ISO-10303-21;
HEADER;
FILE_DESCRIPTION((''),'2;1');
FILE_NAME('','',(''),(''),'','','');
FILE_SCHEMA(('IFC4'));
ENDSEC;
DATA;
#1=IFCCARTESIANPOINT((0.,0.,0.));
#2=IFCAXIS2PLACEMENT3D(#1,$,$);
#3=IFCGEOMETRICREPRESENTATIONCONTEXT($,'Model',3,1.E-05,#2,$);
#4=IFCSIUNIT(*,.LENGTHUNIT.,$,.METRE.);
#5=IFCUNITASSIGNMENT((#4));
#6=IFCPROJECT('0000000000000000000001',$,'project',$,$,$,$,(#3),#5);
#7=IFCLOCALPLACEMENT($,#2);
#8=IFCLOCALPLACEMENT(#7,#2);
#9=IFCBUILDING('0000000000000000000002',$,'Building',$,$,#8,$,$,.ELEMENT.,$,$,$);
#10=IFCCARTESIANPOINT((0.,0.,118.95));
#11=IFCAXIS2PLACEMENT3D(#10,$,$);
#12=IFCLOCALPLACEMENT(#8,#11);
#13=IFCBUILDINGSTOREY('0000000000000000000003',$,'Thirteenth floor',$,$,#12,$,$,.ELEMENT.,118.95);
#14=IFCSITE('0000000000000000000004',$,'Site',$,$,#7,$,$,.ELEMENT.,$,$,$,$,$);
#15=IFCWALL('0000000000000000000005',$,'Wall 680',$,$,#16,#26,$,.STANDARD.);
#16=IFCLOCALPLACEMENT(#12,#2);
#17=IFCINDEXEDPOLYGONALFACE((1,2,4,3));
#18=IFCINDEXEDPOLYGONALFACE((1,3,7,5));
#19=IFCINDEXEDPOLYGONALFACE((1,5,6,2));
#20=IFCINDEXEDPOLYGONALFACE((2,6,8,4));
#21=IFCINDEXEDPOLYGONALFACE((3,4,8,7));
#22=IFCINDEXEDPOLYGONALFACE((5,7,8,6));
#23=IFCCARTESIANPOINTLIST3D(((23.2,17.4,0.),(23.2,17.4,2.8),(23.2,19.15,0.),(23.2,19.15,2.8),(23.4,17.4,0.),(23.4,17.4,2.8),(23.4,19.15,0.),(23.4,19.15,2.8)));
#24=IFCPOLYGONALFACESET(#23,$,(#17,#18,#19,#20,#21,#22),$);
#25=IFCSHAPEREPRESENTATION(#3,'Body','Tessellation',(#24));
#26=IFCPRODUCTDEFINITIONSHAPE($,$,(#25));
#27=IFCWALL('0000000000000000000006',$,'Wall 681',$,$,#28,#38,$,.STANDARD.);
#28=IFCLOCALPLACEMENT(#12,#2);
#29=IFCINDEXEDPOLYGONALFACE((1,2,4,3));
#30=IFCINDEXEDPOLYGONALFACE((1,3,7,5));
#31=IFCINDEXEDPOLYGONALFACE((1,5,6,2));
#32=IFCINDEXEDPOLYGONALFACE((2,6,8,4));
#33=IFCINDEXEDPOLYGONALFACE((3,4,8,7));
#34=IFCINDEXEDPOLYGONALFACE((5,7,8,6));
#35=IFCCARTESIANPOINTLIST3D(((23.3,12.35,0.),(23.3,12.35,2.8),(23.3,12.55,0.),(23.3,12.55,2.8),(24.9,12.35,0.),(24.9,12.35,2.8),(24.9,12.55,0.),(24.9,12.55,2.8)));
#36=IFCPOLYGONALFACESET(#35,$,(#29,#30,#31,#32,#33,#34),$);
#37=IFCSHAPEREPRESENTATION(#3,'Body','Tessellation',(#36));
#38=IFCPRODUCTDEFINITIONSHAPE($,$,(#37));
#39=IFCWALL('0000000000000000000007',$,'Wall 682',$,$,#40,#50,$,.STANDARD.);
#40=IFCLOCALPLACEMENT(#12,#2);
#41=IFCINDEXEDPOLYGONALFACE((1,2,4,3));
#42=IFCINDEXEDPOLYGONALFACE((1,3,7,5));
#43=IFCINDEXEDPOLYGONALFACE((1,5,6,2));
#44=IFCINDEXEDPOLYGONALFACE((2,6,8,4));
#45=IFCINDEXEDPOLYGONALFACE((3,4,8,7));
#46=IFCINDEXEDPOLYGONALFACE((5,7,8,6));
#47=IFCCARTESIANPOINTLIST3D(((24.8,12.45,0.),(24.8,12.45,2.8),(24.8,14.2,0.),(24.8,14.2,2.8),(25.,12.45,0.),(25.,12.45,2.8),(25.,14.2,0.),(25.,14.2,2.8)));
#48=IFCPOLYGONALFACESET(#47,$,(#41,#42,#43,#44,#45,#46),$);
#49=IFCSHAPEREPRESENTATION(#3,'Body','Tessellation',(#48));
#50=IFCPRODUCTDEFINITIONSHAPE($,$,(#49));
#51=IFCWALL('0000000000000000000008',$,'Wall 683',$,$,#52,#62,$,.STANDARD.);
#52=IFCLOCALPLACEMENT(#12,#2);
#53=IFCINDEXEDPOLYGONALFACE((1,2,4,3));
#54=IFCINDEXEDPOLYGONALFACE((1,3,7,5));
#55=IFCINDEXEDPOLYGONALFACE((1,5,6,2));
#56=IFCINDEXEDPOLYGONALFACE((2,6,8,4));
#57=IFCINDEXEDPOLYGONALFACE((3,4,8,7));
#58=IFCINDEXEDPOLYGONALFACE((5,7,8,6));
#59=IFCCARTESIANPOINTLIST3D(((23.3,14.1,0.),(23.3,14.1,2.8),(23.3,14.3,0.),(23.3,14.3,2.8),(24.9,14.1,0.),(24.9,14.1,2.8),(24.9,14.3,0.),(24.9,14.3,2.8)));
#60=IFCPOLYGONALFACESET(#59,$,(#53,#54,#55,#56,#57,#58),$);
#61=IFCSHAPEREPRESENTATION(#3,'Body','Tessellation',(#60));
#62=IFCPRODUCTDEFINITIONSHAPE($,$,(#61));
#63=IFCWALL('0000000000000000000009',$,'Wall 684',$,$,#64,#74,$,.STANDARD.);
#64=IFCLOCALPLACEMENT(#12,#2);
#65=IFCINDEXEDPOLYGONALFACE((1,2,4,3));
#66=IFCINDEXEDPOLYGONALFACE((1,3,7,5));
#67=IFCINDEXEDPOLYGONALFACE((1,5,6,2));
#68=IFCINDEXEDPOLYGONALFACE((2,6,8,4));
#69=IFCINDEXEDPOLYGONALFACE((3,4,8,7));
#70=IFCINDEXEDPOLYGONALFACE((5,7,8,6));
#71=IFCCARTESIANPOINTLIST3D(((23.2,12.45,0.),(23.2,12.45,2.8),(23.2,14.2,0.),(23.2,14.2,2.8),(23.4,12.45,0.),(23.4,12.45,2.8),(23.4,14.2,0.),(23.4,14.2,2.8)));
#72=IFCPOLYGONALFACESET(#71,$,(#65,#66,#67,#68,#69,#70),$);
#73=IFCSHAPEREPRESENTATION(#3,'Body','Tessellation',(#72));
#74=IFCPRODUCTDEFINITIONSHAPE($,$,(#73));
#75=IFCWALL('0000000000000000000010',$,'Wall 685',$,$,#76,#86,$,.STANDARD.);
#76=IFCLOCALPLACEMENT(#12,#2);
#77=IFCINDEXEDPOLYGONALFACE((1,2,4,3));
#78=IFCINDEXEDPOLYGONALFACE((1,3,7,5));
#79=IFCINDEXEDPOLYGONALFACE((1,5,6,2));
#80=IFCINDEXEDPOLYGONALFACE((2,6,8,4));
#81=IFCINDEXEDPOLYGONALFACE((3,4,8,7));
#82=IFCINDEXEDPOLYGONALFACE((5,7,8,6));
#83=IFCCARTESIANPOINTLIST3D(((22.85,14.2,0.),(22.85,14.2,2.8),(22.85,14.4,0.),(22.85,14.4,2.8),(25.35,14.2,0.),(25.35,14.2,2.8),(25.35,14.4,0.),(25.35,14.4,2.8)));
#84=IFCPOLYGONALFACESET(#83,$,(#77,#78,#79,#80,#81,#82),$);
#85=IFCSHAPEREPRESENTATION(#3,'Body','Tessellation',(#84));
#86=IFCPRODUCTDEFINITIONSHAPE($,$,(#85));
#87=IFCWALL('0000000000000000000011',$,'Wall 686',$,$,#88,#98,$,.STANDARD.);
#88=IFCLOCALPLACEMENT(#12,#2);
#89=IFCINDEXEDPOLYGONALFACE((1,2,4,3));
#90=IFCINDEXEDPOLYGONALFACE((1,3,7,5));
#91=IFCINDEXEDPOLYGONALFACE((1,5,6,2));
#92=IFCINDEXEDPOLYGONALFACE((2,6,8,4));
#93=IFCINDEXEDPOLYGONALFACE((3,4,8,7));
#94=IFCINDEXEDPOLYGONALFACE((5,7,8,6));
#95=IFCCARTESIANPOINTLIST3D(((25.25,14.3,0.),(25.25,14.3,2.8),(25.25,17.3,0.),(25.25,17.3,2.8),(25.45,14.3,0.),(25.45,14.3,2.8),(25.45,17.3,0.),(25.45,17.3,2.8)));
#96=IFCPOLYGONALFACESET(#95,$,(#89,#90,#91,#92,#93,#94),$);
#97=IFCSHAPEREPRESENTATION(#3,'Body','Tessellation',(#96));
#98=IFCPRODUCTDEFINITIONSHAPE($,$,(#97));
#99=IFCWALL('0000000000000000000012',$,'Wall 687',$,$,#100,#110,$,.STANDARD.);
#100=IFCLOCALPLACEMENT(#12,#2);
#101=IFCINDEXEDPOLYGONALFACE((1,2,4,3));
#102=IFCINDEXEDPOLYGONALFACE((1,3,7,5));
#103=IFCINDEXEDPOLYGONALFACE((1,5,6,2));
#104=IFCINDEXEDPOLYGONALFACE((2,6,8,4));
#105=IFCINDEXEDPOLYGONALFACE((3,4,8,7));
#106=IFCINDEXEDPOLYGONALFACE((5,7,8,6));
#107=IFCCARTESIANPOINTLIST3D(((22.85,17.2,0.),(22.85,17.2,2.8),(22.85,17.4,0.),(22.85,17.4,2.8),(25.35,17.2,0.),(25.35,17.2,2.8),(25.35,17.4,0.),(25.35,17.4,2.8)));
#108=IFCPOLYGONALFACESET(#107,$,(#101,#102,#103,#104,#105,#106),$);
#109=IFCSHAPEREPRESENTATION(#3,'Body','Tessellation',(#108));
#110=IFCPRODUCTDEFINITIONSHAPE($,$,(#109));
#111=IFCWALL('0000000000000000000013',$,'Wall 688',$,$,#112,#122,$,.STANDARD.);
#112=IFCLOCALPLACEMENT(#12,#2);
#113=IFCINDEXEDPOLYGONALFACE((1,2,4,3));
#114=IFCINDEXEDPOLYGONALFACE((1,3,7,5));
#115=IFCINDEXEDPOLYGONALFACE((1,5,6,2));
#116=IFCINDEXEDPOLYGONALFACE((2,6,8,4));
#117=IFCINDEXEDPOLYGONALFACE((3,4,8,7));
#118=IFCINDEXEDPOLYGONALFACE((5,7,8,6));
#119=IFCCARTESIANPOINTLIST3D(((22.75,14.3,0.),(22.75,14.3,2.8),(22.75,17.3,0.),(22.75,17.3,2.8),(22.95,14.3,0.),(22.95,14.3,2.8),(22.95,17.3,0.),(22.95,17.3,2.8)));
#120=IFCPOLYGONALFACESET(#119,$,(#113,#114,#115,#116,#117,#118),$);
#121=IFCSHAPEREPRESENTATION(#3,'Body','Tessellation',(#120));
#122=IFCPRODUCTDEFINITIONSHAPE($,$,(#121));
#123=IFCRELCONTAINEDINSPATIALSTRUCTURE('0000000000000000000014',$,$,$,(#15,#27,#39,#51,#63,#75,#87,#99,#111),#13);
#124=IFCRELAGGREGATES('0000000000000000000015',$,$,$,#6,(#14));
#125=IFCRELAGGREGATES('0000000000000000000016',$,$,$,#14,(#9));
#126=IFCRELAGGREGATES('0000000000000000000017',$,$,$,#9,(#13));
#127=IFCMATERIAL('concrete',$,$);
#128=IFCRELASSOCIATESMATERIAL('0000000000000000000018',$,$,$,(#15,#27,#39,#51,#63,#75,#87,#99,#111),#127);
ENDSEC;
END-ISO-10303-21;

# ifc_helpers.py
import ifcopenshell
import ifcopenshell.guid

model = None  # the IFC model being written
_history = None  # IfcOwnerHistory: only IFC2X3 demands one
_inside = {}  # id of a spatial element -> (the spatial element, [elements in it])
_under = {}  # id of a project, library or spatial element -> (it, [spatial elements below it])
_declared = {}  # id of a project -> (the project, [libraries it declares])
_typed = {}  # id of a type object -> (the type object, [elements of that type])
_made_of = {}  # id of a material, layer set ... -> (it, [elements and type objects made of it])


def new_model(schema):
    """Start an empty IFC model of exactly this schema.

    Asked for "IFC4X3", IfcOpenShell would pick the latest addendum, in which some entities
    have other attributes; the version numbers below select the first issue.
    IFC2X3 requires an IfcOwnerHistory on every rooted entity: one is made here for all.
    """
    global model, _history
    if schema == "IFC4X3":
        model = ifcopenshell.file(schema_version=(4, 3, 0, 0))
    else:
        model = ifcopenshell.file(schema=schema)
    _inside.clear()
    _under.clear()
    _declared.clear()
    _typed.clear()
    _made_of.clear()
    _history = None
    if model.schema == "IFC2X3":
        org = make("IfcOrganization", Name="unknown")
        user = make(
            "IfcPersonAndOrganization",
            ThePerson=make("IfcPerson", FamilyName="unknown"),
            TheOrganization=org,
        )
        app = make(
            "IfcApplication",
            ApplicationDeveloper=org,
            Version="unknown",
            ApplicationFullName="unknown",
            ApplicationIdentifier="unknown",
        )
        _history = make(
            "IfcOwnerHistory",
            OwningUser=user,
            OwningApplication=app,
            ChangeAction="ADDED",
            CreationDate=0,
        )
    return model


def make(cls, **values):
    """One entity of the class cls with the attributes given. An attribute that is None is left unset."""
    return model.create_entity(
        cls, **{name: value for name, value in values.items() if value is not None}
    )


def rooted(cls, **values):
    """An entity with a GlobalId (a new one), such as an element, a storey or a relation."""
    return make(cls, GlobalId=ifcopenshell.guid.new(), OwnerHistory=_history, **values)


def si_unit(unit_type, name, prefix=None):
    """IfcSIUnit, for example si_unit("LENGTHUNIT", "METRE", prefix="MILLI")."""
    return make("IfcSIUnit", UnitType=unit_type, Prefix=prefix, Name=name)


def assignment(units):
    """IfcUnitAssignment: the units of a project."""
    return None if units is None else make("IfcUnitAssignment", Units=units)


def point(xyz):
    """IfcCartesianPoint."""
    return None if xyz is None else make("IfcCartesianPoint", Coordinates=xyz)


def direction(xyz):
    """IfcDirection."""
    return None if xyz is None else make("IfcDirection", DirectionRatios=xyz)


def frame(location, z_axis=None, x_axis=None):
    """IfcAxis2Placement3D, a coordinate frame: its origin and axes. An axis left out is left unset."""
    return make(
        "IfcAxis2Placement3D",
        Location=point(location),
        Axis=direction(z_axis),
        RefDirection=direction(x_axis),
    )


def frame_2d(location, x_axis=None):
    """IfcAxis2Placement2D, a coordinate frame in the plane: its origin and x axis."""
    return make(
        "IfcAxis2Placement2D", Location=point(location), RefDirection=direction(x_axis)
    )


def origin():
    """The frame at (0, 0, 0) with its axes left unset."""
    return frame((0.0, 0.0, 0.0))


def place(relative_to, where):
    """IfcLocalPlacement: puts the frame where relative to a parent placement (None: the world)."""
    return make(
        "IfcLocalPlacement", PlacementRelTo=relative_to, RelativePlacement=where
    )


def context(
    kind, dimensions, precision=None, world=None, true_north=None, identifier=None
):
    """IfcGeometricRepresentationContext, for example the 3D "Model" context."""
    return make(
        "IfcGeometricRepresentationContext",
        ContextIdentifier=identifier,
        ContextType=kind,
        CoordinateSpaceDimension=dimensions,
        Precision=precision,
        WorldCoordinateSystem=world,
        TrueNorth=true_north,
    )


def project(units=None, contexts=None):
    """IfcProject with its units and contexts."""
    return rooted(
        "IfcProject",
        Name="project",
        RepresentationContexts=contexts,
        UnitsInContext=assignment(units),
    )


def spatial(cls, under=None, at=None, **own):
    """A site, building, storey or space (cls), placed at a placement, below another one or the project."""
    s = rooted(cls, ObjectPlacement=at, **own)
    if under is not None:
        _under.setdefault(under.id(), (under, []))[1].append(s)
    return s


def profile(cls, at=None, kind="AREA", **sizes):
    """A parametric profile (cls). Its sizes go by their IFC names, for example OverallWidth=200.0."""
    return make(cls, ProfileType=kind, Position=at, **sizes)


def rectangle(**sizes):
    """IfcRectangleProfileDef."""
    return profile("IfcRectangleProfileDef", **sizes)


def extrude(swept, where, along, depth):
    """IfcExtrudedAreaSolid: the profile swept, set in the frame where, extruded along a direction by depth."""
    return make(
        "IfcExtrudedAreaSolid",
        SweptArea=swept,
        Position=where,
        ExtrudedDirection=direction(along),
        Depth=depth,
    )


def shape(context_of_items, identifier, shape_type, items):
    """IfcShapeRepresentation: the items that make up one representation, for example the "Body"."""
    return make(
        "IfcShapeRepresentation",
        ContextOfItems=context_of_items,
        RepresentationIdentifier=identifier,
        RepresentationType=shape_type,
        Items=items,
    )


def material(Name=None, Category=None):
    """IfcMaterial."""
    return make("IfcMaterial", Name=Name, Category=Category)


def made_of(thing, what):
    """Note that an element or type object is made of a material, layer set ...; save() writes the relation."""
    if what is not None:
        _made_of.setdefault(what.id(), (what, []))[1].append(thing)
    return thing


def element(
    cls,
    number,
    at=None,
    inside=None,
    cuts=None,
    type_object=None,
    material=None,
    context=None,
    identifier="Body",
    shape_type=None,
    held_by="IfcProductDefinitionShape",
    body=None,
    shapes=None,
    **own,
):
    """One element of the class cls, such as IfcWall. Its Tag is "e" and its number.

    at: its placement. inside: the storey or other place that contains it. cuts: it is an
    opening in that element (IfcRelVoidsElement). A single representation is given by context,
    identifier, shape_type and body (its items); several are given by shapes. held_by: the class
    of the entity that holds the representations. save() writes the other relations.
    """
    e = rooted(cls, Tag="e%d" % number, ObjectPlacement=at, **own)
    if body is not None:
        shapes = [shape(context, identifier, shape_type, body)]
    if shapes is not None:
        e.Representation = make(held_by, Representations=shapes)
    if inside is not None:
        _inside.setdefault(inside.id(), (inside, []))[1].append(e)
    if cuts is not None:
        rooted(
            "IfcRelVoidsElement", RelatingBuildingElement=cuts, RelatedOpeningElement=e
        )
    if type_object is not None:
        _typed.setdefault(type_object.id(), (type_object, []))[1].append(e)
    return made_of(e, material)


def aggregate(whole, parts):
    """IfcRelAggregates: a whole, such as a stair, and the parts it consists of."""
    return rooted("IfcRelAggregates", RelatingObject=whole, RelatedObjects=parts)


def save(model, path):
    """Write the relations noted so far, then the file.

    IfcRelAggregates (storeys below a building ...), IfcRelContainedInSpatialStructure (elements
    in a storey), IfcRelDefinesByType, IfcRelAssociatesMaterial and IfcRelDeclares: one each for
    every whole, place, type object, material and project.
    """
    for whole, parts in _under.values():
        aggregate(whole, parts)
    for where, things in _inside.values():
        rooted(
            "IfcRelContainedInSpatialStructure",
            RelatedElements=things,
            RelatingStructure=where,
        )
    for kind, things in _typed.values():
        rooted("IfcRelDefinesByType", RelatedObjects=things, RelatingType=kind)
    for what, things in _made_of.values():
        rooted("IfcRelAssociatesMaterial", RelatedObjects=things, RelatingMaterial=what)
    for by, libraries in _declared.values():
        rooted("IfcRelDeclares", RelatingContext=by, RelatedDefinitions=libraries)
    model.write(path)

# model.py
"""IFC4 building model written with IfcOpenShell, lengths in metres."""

from ifc_helpers import new_model, si_unit, frame, frame_2d, origin, place, context, project, spatial, rectangle, extrude, material, element, save


model = new_model("IFC4")

# Units and contexts
model_context = context("Model", 3, precision=1e-05, world=origin())
ifc_project = project(units=[si_unit("LENGTHUNIT", "METRE")], contexts=[model_context])

# Site, building, storey
site_placement = place(None, origin())
site = spatial("IfcSite", under=ifc_project, at=site_placement, Name="Site", CompositionType="ELEMENT")
building_placement = place(site_placement, origin())
building = spatial("IfcBuilding", under=site, at=building_placement, Name="Building", CompositionType="ELEMENT")
storey_placement = place(building_placement, frame((0.0, 0.0, 118.95)))
storey = spatial("IfcBuildingStorey", under=building, at=storey_placement, Name="Thirteenth floor", CompositionType="ELEMENT", Elevation=118.95)

# Shared definitions
ifc_material = material(Name="concrete")

# Walls
wall_1_placement = place(storey_placement, frame((23.3, 19.15, 0.0), z_axis=(0.0, 0.0, 1.0), x_axis=(0.0, -1.0, 0.0)))
element("IfcWall", 1, at=wall_1_placement, inside=storey, material=ifc_material, Name="Wall 680", PredefinedType="STANDARD", context=model_context, shape_type="SweptSolid", body=[
    extrude(rectangle(XDim=1.75, YDim=0.2, at=frame_2d((0.875, 0.0))), origin(), (0.0, 0.0, 1.0), 2.8),
])
wall_2_placement = place(storey_placement, frame((23.3, 12.45, 0.0), z_axis=(0.0, 0.0, 1.0), x_axis=(1.0, 0.0, 0.0)))
element("IfcWall", 2, at=wall_2_placement, inside=storey, material=ifc_material, Name="Wall 681", PredefinedType="STANDARD", context=model_context, shape_type="SweptSolid", body=[
    extrude(rectangle(XDim=1.6, YDim=0.2, at=frame_2d((0.8, 0.0))), origin(), (0.0, 0.0, 1.0), 2.8),
])
wall_3_placement = place(storey_placement, frame((24.9, 12.45, 0.0), z_axis=(0.0, 0.0, 1.0), x_axis=(0.0, 1.0, 0.0)))
element("IfcWall", 3, at=wall_3_placement, inside=storey, material=ifc_material, Name="Wall 682", PredefinedType="STANDARD", context=model_context, shape_type="SweptSolid", body=[
    extrude(rectangle(XDim=1.75, YDim=0.2, at=frame_2d((0.875, 0.0))), origin(), (0.0, 0.0, 1.0), 2.8),
])
wall_4_placement = place(storey_placement, frame((24.9, 14.2, 0.0), z_axis=(0.0, 0.0, 1.0), x_axis=(-1.0, 0.0, 0.0)))
element("IfcWall", 4, at=wall_4_placement, inside=storey, material=ifc_material, Name="Wall 683", PredefinedType="STANDARD", context=model_context, shape_type="SweptSolid", body=[
    extrude(rectangle(XDim=1.6, YDim=0.2, at=frame_2d((0.8, 0.0))), origin(), (0.0, 0.0, 1.0), 2.8),
])
wall_5_placement = place(storey_placement, frame((23.3, 14.2, 0.0), z_axis=(0.0, 0.0, 1.0), x_axis=(0.0, -1.0, 0.0)))
element("IfcWall", 5, at=wall_5_placement, inside=storey, material=ifc_material, Name="Wall 684", PredefinedType="STANDARD", context=model_context, shape_type="SweptSolid", body=[
    extrude(rectangle(XDim=1.75, YDim=0.2, at=frame_2d((0.875, 0.0))), origin(), (0.0, 0.0, 1.0), 2.8),
])
wall_6_placement = place(storey_placement, frame((22.85, 14.3, 0.0), z_axis=(0.0, 0.0, 1.0), x_axis=(1.0, 0.0, 0.0)))
element("IfcWall", 6, at=wall_6_placement, inside=storey, material=ifc_material, Name="Wall 685", PredefinedType="STANDARD", context=model_context, shape_type="SweptSolid", body=[
    extrude(rectangle(XDim=2.5, YDim=0.2, at=frame_2d((1.25, 0.0))), origin(), (0.0, 0.0, 1.0), 2.8),
])
wall_7_placement = place(storey_placement, frame((25.35, 14.3, 0.0), z_axis=(0.0, 0.0, 1.0), x_axis=(0.0, 1.0, 0.0)))
element("IfcWall", 7, at=wall_7_placement, inside=storey, material=ifc_material, Name="Wall 686", PredefinedType="STANDARD", context=model_context, shape_type="SweptSolid", body=[
    extrude(rectangle(XDim=3.0, YDim=0.2, at=frame_2d((1.5, 0.0))), origin(), (0.0, 0.0, 1.0), 2.8),
])
wall_8_placement = place(storey_placement, frame((25.35, 17.3, 0.0), z_axis=(0.0, 0.0, 1.0), x_axis=(-1.0, 0.0, 0.0)))
element("IfcWall", 8, at=wall_8_placement, inside=storey, material=ifc_material, Name="Wall 687", PredefinedType="STANDARD", context=model_context, shape_type="SweptSolid", body=[
    extrude(rectangle(XDim=2.5, YDim=0.2, at=frame_2d((1.25, 0.0))), origin(), (0.0, 0.0, 1.0), 2.8),
])
wall_9_placement = place(storey_placement, frame((22.85, 17.3, 0.0), z_axis=(0.0, 0.0, 1.0), x_axis=(0.0, -1.0, 0.0)))
element("IfcWall", 9, at=wall_9_placement, inside=storey, material=ifc_material, Name="Wall 688", PredefinedType="STANDARD", context=model_context, shape_type="SweptSolid", body=[
    extrude(rectangle(XDim=3.0, YDim=0.2, at=frame_2d((1.5, 0.0))), origin(), (0.0, 0.0, 1.0), 2.8),
])

save(model, "model.ifc")
